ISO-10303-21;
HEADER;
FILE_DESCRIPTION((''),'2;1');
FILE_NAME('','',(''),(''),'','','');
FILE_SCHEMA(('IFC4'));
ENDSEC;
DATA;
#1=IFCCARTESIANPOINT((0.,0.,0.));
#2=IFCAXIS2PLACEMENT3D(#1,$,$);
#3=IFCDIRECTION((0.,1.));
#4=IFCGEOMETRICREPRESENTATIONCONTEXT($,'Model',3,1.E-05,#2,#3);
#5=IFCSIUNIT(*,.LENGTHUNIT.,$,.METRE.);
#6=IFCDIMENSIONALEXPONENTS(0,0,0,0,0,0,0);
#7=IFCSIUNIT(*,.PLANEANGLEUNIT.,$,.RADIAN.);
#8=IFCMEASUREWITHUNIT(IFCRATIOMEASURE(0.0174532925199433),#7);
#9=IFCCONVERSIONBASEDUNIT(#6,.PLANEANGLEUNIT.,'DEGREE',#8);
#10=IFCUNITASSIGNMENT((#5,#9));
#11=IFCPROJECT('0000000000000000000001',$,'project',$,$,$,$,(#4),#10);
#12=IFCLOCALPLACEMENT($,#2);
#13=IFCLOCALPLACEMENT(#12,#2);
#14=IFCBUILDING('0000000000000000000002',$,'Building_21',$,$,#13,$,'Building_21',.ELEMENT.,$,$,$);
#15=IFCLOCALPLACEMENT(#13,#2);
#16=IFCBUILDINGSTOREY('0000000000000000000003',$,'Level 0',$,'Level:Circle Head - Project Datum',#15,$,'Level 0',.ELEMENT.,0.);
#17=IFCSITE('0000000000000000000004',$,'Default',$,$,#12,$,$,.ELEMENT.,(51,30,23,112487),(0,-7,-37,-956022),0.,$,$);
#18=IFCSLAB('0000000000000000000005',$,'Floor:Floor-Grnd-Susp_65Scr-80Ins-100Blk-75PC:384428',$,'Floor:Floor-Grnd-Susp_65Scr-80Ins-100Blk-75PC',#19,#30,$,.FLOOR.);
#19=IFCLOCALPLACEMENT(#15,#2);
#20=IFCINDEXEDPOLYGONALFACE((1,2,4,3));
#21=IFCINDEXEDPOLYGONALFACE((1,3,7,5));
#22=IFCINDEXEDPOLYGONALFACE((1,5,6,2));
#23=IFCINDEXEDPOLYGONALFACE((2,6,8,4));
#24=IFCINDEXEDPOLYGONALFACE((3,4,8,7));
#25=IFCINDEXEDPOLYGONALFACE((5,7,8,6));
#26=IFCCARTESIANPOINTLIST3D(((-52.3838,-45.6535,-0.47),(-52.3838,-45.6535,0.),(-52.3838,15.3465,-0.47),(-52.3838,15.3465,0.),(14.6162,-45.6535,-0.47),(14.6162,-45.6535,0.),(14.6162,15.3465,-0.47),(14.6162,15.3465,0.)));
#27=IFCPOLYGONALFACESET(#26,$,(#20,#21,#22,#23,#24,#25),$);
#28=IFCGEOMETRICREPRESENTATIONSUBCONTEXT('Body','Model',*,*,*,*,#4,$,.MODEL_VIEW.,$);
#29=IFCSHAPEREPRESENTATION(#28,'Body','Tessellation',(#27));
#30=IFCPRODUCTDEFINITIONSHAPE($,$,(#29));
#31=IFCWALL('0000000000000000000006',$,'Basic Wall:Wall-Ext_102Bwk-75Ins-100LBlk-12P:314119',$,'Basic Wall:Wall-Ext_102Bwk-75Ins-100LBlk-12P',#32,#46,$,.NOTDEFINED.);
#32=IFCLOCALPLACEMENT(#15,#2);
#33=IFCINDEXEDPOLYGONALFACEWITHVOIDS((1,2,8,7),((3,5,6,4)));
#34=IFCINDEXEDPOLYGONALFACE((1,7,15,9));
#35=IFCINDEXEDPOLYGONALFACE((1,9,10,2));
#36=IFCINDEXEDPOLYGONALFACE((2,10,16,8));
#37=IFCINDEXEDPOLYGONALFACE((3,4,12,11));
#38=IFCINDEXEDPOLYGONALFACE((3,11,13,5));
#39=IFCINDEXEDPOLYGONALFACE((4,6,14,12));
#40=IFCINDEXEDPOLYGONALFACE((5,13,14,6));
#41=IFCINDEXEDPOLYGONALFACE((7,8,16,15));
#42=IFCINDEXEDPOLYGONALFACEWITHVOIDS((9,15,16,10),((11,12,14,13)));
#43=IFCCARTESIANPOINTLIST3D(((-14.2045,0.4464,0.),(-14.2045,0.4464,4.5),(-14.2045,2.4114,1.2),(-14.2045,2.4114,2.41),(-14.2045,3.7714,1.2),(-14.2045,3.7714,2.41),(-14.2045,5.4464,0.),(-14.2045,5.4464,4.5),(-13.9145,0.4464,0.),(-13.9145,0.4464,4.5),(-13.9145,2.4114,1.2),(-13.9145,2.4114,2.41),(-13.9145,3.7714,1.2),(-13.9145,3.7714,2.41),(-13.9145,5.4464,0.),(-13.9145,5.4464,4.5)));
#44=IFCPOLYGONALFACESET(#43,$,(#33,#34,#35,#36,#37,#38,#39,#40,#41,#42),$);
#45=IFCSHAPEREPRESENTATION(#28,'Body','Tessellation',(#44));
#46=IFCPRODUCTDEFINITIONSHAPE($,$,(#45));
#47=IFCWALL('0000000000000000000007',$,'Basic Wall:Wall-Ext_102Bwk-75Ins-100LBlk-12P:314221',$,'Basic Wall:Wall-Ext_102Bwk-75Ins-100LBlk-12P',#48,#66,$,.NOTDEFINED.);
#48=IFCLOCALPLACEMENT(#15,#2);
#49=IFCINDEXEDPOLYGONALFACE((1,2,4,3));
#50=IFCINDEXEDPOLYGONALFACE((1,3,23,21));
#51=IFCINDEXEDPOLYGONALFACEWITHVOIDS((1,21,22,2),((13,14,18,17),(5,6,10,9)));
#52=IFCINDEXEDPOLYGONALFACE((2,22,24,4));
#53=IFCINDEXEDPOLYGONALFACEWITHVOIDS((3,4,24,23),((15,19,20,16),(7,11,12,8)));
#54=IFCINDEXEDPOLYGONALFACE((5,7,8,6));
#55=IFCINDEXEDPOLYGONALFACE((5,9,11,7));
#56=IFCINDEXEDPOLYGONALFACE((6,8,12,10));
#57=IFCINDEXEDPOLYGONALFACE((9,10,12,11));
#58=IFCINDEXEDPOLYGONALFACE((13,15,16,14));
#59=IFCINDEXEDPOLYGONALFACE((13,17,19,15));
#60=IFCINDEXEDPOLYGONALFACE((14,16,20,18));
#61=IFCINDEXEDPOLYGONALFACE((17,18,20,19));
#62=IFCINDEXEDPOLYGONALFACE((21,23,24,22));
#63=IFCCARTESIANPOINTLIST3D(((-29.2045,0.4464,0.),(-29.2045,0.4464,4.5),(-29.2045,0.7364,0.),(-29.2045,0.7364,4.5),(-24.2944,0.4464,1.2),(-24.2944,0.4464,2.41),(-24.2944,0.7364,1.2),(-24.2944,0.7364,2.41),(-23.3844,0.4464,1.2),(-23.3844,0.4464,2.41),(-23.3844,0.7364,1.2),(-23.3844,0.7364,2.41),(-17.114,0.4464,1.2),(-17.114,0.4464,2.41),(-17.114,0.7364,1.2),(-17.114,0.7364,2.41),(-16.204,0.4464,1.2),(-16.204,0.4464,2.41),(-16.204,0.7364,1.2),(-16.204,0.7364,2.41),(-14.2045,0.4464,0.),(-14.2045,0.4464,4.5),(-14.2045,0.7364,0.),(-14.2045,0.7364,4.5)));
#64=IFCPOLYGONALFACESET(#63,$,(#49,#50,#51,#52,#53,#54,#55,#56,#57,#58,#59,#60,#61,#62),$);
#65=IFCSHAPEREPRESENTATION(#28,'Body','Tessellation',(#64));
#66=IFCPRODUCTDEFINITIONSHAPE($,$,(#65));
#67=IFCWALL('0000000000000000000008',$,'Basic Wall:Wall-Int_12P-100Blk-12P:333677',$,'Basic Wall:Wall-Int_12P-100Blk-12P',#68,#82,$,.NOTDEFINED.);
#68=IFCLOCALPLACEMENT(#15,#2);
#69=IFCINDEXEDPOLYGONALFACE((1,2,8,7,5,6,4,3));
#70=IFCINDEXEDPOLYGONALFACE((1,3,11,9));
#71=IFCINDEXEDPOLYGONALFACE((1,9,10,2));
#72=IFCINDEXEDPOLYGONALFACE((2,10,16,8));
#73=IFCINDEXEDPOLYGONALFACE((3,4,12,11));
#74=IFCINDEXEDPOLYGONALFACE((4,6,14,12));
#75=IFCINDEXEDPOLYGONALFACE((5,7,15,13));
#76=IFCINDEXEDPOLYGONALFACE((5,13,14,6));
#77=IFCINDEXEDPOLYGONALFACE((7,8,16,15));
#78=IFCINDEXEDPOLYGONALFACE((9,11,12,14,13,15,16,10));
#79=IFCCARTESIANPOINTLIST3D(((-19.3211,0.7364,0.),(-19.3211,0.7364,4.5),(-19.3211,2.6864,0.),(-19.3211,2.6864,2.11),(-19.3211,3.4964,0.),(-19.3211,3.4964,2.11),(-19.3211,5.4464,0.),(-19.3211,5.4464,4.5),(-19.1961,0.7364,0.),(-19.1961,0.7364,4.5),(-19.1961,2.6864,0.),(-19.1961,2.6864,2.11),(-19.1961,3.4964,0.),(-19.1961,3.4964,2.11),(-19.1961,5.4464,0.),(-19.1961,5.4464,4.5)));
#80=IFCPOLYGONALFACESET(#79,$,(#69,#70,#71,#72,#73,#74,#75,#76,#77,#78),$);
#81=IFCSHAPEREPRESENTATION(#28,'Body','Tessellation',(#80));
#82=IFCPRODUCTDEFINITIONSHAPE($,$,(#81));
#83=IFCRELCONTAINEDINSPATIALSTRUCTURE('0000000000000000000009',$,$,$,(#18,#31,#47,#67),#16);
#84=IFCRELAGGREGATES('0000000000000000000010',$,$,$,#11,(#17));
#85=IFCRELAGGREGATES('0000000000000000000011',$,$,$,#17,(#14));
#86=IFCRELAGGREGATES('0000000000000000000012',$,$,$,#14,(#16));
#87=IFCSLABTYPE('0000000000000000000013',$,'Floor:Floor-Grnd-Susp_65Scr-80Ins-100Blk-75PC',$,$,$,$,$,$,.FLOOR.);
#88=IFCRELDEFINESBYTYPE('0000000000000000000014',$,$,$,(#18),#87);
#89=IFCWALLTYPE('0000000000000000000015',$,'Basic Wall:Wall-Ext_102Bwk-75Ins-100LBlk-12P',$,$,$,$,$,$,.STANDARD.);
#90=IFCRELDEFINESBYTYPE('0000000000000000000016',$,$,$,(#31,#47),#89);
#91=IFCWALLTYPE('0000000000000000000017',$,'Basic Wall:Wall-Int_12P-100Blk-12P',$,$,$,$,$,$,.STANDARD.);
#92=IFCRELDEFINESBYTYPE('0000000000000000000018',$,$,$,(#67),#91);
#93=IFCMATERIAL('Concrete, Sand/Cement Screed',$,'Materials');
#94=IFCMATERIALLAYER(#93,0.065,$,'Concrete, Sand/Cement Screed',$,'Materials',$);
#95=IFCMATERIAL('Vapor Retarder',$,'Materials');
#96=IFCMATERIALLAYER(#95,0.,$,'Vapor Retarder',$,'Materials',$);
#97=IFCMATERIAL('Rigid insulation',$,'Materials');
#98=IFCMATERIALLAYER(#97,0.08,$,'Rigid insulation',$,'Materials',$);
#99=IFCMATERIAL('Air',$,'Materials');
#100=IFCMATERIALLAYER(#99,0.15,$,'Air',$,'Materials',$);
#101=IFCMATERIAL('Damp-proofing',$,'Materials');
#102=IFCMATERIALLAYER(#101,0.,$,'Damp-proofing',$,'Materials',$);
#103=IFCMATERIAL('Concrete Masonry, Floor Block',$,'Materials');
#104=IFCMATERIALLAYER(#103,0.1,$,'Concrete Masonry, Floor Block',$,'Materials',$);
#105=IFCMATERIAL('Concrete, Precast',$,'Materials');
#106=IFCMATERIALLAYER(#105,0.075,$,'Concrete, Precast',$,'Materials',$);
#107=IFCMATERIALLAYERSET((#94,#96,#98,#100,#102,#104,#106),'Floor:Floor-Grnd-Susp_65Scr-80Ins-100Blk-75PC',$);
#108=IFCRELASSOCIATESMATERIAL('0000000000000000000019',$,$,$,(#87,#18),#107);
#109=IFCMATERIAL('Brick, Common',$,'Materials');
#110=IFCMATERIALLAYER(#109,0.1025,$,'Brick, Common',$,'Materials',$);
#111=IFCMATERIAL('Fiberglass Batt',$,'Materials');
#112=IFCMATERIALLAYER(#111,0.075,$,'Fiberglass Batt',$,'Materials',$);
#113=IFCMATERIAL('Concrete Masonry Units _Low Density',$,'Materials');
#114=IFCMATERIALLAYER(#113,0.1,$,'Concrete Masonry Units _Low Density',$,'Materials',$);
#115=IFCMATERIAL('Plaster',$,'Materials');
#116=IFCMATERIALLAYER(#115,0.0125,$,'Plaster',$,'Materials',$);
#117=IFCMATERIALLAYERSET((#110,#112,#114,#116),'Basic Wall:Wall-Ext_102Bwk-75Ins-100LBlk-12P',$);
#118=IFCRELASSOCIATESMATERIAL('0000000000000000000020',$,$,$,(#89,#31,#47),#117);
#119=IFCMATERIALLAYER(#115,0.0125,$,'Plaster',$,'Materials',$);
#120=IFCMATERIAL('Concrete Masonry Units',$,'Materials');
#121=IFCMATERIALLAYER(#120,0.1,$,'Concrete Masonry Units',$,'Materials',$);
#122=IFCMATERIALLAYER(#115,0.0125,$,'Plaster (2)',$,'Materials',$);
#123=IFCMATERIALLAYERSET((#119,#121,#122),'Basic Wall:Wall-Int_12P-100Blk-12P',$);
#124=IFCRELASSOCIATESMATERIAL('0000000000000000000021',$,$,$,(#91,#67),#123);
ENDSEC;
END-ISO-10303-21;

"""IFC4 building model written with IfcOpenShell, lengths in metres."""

from ifc_helpers import new_model, entity, si_unit, converted_unit, direction, frame, frame_2d, origin, place, context, subcontext, project, spatial, rectangle, extrude, material, layer, layer_set, layer_usage, type_object, element, save


model = new_model("IFC4")

# Units and contexts
model_context = context("Model", 3, precision=1e-05, world=origin(), true_north=direction((0.0, 1.0)))
body_context = subcontext(model_context, "Body", "Model", "MODEL_VIEW")
ifc_project = project(units=[si_unit("LENGTHUNIT", "METRE"), converted_unit("PLANEANGLEUNIT", "DEGREE", entity("IfcRatioMeasure", 0.0174532925199433), si_unit("PLANEANGLEUNIT", "RADIAN"), dimensions=[0, 0, 0, 0, 0, 0, 0])], contexts=[model_context])

# Site, building, storey
site_placement = place(None, origin())
site = spatial("IfcSite", under=ifc_project, at=site_placement, Name="Default", CompositionType="ELEMENT", RefLatitude=(51, 30, 23, 112487), RefLongitude=(0, -7, -37, -956022), RefElevation=0.0)
building_placement = place(site_placement, origin())
building = spatial("IfcBuilding", under=site, at=building_placement, Name="Building_21", LongName="Building_21", CompositionType="ELEMENT")
storey_placement = place(building_placement, origin())
storey = spatial("IfcBuildingStorey", under=building, at=storey_placement, Name="Level 0", ObjectType="Level:Circle Head - Project Datum", LongName="Level 0", CompositionType="ELEMENT", Elevation=0.0)

# Slab
ifc_material_1 = material(Name="Concrete, Sand/Cement Screed", Category="Materials")
ifc_layer_1 = layer(ifc_material_1, 0.065, Name="Concrete, Sand/Cement Screed", Category="Materials")
ifc_material_2 = material(Name="Vapor Retarder", Category="Materials")
ifc_layer_2 = layer(ifc_material_2, 0.0, Name="Vapor Retarder", Category="Materials")
ifc_material_3 = material(Name="Rigid insulation", Category="Materials")
ifc_layer_3 = layer(ifc_material_3, 0.08, Name="Rigid insulation", Category="Materials")
ifc_material_4 = material(Name="Air", Category="Materials")
ifc_layer_4 = layer(ifc_material_4, 0.15, Name="Air", Category="Materials")
ifc_material_5 = material(Name="Damp-proofing", Category="Materials")
ifc_layer_5 = layer(ifc_material_5, 0.0, Name="Damp-proofing", Category="Materials")
ifc_material_6 = material(Name="Concrete Masonry, Floor Block", Category="Materials")
ifc_layer_6 = layer(ifc_material_6, 0.1, Name="Concrete Masonry, Floor Block", Category="Materials")
ifc_material_7 = material(Name="Concrete, Precast", Category="Materials")
ifc_layer_7 = layer(ifc_material_7, 0.075, Name="Concrete, Precast", Category="Materials")
ifc_layer_set_1 = layer_set([ifc_layer_1, ifc_layer_2, ifc_layer_3, ifc_layer_4, ifc_layer_5, ifc_layer_6, ifc_layer_7], Name="Floor:Floor-Grnd-Susp_65Scr-80Ins-100Blk-75PC")
ifc_layer_usage_1 = layer_usage(ifc_layer_set_1, "AXIS3", "POSITIVE", 0.0)
slab_type = type_object("IfcSlabType", Name="Floor:Floor-Grnd-Susp_65Scr-80Ins-100Blk-75PC", PredefinedType="FLOOR", material=ifc_layer_set_1)
slab_placement = place(storey_placement, origin())
element("IfcSlab", 1, at=slab_placement, inside=storey, type_object=slab_type, material=ifc_layer_usage_1, Name="Floor:Floor-Grnd-Susp_65Scr-80Ins-100Blk-75PC:384428", ObjectType="Floor:Floor-Grnd-Susp_65Scr-80Ins-100Blk-75PC", PredefinedType="FLOOR", context=body_context, shape_type="SweptSolid", body=[
    extrude(rectangle(XDim=61.0, YDim=67.0, at=frame_2d((0.0, 0.0), x_axis=(1.0, 0.0))), frame((-18.8838, -15.1535, 0.0), z_axis=(0.0, 0.0, -1.0), x_axis=(0.0, 1.0, 0.0)), (0.0, 0.0, 1.0), 0.47),
])

# Wall, opening
ifc_material_8 = material(Name="Brick, Common", Category="Materials")
ifc_layer_8 = layer(ifc_material_8, 0.1025, Name="Brick, Common", Category="Materials")
ifc_material_9 = material(Name="Fiberglass Batt", Category="Materials")
ifc_layer_9 = layer(ifc_material_9, 0.075, Name="Fiberglass Batt", Category="Materials")
ifc_material_10 = material(Name="Concrete Masonry Units _Low Density", Category="Materials")
ifc_layer_10 = layer(ifc_material_10, 0.1, Name="Concrete Masonry Units _Low Density", Category="Materials")
ifc_material_11 = material(Name="Plaster", Category="Materials")
ifc_layer_11 = layer(ifc_material_11, 0.0125, Name="Plaster", Category="Materials")
ifc_layer_set_2 = layer_set([ifc_layer_8, ifc_layer_9, ifc_layer_10, ifc_layer_11], Name="Basic Wall:Wall-Ext_102Bwk-75Ins-100LBlk-12P")
ifc_layer_usage_2 = layer_usage(ifc_layer_set_2, "AXIS2", "NEGATIVE", 0.145)
wall_type_1 = type_object("IfcWallType", Name="Basic Wall:Wall-Ext_102Bwk-75Ins-100LBlk-12P", PredefinedType="STANDARD", material=ifc_layer_set_2)
wall_1_placement = place(storey_placement, frame((-14.0595, 5.4464, 0.0), z_axis=(0.0, 0.0, 1.0), x_axis=(0.0, -1.0, 0.0)))
wall_1 = element("IfcWall", 2, at=wall_1_placement, inside=storey, type_object=wall_type_1, material=ifc_layer_usage_2, Name="Basic Wall:Wall-Ext_102Bwk-75Ins-100LBlk-12P:314119", ObjectType="Basic Wall:Wall-Ext_102Bwk-75Ins-100LBlk-12P", PredefinedType="NOTDEFINED", context=body_context, shape_type="SweptSolid", body=[
    extrude(rectangle(XDim=5.0, YDim=0.29, at=frame_2d((2.5, 0.0), x_axis=(-1.0, 0.0))), origin(), (0.0, 0.0, 1.0), 4.5),
])
opening_1_placement = place(wall_1_placement, frame((1.675, -0.145, 1.2)))
element("IfcOpeningElement", 3, at=opening_1_placement, cuts=wall_1, PredefinedType="OPENING", context=body_context, shape_type="SweptSolid", body=[
    extrude(rectangle(XDim=1.21, YDim=1.36, at=frame_2d((0.605, 0.68), x_axis=(-1.0, 0.0))), frame((0.0, 0.0, 0.0), z_axis=(0.0, 1.0, 0.0), x_axis=(0.0, 0.0, 1.0)), (0.0, 0.0, 1.0), 0.29),
])

# Wall, openings
ifc_layer_usage_3 = layer_usage(ifc_layer_set_2, "AXIS2", "NEGATIVE", 0.145)
wall_2_placement = place(storey_placement, frame((-14.2045, 0.5914, 0.0), z_axis=(0.0, 0.0, 1.0), x_axis=(-1.0, 0.0, 0.0)))
wall_2 = element("IfcWall", 4, at=wall_2_placement, inside=storey, type_object=wall_type_1, material=ifc_layer_usage_3, Name="Basic Wall:Wall-Ext_102Bwk-75Ins-100LBlk-12P:314221", ObjectType="Basic Wall:Wall-Ext_102Bwk-75Ins-100LBlk-12P", PredefinedType="NOTDEFINED", context=body_context, shape_type="SweptSolid", body=[
    extrude(rectangle(XDim=15.0, YDim=0.29, at=frame_2d((7.5, 0.0), x_axis=(-1.0, 0.0))), origin(), (0.0, 0.0, 1.0), 4.5),
])
opening_2_placement = place(wall_2_placement, frame((1.9995, -0.145, 1.2)))
element("IfcOpeningElement", 5, at=opening_2_placement, cuts=wall_2, PredefinedType="OPENING", context=body_context, shape_type="SweptSolid", body=[
    extrude(rectangle(XDim=1.21, YDim=0.91, at=frame_2d((0.605, 0.455), x_axis=(-1.0, 0.0))), frame((0.0, 0.0, 0.0), z_axis=(0.0, 1.0, 0.0), x_axis=(0.0, 0.0, 1.0)), (0.0, 0.0, 1.0), 0.29),
])
opening_3_placement = place(wall_2_placement, frame((9.1799, -0.145, 1.2)))
element("IfcOpeningElement", 6, at=opening_3_placement, cuts=wall_2, PredefinedType="OPENING", context=body_context, shape_type="SweptSolid", body=[
    extrude(rectangle(XDim=1.21, YDim=0.91, at=frame_2d((0.605, 0.455), x_axis=(-1.0, 0.0))), frame((0.0, 0.0, 0.0), z_axis=(0.0, 1.0, 0.0), x_axis=(0.0, 0.0, 1.0)), (0.0, 0.0, 1.0), 0.29),
])

# Wall, opening
ifc_layer_12 = layer(ifc_material_11, 0.0125, Name="Plaster", Category="Materials")
ifc_material_12 = material(Name="Concrete Masonry Units", Category="Materials")
ifc_layer_13 = layer(ifc_material_12, 0.1, Name="Concrete Masonry Units", Category="Materials")
ifc_layer_14 = layer(ifc_material_11, 0.0125, Name="Plaster (2)", Category="Materials")
ifc_layer_set_3 = layer_set([ifc_layer_12, ifc_layer_13, ifc_layer_14], Name="Basic Wall:Wall-Int_12P-100Blk-12P")
ifc_layer_usage_4 = layer_usage(ifc_layer_set_3, "AXIS2", "NEGATIVE", 0.0625)
wall_type_2 = type_object("IfcWallType", Name="Basic Wall:Wall-Int_12P-100Blk-12P", PredefinedType="STANDARD", material=ifc_layer_set_3)
wall_3_placement = place(storey_placement, frame((-19.2586, 5.4464, 0.0), z_axis=(0.0, 0.0, 1.0), x_axis=(0.0, -1.0, 0.0)))
wall_3 = element("IfcWall", 7, at=wall_3_placement, inside=storey, type_object=wall_type_2, material=ifc_layer_usage_4, Name="Basic Wall:Wall-Int_12P-100Blk-12P:333677", ObjectType="Basic Wall:Wall-Int_12P-100Blk-12P", PredefinedType="NOTDEFINED", context=body_context, shape_type="SweptSolid", body=[
    extrude(rectangle(XDim=4.71, YDim=0.125, at=frame_2d((2.355, 0.0), x_axis=(1.0, 0.0))), origin(), (0.0, 0.0, 1.0), 4.5),
])
opening_4_placement = place(wall_3_placement, frame((1.95, -0.0625, 0.0)))
element("IfcOpeningElement", 8, at=opening_4_placement, cuts=wall_3, PredefinedType="OPENING", context=body_context, shape_type="SweptSolid", body=[
    extrude(rectangle(XDim=2.11, YDim=0.81, at=frame_2d((1.055, 0.405), x_axis=(1.0, 0.0))), frame((0.0, 0.0, 0.0), z_axis=(0.0, 1.0, 0.0), x_axis=(0.0, 0.0, 1.0)), (0.0, 0.0, 1.0), 0.125),
])

save(model, "model.ifc")
